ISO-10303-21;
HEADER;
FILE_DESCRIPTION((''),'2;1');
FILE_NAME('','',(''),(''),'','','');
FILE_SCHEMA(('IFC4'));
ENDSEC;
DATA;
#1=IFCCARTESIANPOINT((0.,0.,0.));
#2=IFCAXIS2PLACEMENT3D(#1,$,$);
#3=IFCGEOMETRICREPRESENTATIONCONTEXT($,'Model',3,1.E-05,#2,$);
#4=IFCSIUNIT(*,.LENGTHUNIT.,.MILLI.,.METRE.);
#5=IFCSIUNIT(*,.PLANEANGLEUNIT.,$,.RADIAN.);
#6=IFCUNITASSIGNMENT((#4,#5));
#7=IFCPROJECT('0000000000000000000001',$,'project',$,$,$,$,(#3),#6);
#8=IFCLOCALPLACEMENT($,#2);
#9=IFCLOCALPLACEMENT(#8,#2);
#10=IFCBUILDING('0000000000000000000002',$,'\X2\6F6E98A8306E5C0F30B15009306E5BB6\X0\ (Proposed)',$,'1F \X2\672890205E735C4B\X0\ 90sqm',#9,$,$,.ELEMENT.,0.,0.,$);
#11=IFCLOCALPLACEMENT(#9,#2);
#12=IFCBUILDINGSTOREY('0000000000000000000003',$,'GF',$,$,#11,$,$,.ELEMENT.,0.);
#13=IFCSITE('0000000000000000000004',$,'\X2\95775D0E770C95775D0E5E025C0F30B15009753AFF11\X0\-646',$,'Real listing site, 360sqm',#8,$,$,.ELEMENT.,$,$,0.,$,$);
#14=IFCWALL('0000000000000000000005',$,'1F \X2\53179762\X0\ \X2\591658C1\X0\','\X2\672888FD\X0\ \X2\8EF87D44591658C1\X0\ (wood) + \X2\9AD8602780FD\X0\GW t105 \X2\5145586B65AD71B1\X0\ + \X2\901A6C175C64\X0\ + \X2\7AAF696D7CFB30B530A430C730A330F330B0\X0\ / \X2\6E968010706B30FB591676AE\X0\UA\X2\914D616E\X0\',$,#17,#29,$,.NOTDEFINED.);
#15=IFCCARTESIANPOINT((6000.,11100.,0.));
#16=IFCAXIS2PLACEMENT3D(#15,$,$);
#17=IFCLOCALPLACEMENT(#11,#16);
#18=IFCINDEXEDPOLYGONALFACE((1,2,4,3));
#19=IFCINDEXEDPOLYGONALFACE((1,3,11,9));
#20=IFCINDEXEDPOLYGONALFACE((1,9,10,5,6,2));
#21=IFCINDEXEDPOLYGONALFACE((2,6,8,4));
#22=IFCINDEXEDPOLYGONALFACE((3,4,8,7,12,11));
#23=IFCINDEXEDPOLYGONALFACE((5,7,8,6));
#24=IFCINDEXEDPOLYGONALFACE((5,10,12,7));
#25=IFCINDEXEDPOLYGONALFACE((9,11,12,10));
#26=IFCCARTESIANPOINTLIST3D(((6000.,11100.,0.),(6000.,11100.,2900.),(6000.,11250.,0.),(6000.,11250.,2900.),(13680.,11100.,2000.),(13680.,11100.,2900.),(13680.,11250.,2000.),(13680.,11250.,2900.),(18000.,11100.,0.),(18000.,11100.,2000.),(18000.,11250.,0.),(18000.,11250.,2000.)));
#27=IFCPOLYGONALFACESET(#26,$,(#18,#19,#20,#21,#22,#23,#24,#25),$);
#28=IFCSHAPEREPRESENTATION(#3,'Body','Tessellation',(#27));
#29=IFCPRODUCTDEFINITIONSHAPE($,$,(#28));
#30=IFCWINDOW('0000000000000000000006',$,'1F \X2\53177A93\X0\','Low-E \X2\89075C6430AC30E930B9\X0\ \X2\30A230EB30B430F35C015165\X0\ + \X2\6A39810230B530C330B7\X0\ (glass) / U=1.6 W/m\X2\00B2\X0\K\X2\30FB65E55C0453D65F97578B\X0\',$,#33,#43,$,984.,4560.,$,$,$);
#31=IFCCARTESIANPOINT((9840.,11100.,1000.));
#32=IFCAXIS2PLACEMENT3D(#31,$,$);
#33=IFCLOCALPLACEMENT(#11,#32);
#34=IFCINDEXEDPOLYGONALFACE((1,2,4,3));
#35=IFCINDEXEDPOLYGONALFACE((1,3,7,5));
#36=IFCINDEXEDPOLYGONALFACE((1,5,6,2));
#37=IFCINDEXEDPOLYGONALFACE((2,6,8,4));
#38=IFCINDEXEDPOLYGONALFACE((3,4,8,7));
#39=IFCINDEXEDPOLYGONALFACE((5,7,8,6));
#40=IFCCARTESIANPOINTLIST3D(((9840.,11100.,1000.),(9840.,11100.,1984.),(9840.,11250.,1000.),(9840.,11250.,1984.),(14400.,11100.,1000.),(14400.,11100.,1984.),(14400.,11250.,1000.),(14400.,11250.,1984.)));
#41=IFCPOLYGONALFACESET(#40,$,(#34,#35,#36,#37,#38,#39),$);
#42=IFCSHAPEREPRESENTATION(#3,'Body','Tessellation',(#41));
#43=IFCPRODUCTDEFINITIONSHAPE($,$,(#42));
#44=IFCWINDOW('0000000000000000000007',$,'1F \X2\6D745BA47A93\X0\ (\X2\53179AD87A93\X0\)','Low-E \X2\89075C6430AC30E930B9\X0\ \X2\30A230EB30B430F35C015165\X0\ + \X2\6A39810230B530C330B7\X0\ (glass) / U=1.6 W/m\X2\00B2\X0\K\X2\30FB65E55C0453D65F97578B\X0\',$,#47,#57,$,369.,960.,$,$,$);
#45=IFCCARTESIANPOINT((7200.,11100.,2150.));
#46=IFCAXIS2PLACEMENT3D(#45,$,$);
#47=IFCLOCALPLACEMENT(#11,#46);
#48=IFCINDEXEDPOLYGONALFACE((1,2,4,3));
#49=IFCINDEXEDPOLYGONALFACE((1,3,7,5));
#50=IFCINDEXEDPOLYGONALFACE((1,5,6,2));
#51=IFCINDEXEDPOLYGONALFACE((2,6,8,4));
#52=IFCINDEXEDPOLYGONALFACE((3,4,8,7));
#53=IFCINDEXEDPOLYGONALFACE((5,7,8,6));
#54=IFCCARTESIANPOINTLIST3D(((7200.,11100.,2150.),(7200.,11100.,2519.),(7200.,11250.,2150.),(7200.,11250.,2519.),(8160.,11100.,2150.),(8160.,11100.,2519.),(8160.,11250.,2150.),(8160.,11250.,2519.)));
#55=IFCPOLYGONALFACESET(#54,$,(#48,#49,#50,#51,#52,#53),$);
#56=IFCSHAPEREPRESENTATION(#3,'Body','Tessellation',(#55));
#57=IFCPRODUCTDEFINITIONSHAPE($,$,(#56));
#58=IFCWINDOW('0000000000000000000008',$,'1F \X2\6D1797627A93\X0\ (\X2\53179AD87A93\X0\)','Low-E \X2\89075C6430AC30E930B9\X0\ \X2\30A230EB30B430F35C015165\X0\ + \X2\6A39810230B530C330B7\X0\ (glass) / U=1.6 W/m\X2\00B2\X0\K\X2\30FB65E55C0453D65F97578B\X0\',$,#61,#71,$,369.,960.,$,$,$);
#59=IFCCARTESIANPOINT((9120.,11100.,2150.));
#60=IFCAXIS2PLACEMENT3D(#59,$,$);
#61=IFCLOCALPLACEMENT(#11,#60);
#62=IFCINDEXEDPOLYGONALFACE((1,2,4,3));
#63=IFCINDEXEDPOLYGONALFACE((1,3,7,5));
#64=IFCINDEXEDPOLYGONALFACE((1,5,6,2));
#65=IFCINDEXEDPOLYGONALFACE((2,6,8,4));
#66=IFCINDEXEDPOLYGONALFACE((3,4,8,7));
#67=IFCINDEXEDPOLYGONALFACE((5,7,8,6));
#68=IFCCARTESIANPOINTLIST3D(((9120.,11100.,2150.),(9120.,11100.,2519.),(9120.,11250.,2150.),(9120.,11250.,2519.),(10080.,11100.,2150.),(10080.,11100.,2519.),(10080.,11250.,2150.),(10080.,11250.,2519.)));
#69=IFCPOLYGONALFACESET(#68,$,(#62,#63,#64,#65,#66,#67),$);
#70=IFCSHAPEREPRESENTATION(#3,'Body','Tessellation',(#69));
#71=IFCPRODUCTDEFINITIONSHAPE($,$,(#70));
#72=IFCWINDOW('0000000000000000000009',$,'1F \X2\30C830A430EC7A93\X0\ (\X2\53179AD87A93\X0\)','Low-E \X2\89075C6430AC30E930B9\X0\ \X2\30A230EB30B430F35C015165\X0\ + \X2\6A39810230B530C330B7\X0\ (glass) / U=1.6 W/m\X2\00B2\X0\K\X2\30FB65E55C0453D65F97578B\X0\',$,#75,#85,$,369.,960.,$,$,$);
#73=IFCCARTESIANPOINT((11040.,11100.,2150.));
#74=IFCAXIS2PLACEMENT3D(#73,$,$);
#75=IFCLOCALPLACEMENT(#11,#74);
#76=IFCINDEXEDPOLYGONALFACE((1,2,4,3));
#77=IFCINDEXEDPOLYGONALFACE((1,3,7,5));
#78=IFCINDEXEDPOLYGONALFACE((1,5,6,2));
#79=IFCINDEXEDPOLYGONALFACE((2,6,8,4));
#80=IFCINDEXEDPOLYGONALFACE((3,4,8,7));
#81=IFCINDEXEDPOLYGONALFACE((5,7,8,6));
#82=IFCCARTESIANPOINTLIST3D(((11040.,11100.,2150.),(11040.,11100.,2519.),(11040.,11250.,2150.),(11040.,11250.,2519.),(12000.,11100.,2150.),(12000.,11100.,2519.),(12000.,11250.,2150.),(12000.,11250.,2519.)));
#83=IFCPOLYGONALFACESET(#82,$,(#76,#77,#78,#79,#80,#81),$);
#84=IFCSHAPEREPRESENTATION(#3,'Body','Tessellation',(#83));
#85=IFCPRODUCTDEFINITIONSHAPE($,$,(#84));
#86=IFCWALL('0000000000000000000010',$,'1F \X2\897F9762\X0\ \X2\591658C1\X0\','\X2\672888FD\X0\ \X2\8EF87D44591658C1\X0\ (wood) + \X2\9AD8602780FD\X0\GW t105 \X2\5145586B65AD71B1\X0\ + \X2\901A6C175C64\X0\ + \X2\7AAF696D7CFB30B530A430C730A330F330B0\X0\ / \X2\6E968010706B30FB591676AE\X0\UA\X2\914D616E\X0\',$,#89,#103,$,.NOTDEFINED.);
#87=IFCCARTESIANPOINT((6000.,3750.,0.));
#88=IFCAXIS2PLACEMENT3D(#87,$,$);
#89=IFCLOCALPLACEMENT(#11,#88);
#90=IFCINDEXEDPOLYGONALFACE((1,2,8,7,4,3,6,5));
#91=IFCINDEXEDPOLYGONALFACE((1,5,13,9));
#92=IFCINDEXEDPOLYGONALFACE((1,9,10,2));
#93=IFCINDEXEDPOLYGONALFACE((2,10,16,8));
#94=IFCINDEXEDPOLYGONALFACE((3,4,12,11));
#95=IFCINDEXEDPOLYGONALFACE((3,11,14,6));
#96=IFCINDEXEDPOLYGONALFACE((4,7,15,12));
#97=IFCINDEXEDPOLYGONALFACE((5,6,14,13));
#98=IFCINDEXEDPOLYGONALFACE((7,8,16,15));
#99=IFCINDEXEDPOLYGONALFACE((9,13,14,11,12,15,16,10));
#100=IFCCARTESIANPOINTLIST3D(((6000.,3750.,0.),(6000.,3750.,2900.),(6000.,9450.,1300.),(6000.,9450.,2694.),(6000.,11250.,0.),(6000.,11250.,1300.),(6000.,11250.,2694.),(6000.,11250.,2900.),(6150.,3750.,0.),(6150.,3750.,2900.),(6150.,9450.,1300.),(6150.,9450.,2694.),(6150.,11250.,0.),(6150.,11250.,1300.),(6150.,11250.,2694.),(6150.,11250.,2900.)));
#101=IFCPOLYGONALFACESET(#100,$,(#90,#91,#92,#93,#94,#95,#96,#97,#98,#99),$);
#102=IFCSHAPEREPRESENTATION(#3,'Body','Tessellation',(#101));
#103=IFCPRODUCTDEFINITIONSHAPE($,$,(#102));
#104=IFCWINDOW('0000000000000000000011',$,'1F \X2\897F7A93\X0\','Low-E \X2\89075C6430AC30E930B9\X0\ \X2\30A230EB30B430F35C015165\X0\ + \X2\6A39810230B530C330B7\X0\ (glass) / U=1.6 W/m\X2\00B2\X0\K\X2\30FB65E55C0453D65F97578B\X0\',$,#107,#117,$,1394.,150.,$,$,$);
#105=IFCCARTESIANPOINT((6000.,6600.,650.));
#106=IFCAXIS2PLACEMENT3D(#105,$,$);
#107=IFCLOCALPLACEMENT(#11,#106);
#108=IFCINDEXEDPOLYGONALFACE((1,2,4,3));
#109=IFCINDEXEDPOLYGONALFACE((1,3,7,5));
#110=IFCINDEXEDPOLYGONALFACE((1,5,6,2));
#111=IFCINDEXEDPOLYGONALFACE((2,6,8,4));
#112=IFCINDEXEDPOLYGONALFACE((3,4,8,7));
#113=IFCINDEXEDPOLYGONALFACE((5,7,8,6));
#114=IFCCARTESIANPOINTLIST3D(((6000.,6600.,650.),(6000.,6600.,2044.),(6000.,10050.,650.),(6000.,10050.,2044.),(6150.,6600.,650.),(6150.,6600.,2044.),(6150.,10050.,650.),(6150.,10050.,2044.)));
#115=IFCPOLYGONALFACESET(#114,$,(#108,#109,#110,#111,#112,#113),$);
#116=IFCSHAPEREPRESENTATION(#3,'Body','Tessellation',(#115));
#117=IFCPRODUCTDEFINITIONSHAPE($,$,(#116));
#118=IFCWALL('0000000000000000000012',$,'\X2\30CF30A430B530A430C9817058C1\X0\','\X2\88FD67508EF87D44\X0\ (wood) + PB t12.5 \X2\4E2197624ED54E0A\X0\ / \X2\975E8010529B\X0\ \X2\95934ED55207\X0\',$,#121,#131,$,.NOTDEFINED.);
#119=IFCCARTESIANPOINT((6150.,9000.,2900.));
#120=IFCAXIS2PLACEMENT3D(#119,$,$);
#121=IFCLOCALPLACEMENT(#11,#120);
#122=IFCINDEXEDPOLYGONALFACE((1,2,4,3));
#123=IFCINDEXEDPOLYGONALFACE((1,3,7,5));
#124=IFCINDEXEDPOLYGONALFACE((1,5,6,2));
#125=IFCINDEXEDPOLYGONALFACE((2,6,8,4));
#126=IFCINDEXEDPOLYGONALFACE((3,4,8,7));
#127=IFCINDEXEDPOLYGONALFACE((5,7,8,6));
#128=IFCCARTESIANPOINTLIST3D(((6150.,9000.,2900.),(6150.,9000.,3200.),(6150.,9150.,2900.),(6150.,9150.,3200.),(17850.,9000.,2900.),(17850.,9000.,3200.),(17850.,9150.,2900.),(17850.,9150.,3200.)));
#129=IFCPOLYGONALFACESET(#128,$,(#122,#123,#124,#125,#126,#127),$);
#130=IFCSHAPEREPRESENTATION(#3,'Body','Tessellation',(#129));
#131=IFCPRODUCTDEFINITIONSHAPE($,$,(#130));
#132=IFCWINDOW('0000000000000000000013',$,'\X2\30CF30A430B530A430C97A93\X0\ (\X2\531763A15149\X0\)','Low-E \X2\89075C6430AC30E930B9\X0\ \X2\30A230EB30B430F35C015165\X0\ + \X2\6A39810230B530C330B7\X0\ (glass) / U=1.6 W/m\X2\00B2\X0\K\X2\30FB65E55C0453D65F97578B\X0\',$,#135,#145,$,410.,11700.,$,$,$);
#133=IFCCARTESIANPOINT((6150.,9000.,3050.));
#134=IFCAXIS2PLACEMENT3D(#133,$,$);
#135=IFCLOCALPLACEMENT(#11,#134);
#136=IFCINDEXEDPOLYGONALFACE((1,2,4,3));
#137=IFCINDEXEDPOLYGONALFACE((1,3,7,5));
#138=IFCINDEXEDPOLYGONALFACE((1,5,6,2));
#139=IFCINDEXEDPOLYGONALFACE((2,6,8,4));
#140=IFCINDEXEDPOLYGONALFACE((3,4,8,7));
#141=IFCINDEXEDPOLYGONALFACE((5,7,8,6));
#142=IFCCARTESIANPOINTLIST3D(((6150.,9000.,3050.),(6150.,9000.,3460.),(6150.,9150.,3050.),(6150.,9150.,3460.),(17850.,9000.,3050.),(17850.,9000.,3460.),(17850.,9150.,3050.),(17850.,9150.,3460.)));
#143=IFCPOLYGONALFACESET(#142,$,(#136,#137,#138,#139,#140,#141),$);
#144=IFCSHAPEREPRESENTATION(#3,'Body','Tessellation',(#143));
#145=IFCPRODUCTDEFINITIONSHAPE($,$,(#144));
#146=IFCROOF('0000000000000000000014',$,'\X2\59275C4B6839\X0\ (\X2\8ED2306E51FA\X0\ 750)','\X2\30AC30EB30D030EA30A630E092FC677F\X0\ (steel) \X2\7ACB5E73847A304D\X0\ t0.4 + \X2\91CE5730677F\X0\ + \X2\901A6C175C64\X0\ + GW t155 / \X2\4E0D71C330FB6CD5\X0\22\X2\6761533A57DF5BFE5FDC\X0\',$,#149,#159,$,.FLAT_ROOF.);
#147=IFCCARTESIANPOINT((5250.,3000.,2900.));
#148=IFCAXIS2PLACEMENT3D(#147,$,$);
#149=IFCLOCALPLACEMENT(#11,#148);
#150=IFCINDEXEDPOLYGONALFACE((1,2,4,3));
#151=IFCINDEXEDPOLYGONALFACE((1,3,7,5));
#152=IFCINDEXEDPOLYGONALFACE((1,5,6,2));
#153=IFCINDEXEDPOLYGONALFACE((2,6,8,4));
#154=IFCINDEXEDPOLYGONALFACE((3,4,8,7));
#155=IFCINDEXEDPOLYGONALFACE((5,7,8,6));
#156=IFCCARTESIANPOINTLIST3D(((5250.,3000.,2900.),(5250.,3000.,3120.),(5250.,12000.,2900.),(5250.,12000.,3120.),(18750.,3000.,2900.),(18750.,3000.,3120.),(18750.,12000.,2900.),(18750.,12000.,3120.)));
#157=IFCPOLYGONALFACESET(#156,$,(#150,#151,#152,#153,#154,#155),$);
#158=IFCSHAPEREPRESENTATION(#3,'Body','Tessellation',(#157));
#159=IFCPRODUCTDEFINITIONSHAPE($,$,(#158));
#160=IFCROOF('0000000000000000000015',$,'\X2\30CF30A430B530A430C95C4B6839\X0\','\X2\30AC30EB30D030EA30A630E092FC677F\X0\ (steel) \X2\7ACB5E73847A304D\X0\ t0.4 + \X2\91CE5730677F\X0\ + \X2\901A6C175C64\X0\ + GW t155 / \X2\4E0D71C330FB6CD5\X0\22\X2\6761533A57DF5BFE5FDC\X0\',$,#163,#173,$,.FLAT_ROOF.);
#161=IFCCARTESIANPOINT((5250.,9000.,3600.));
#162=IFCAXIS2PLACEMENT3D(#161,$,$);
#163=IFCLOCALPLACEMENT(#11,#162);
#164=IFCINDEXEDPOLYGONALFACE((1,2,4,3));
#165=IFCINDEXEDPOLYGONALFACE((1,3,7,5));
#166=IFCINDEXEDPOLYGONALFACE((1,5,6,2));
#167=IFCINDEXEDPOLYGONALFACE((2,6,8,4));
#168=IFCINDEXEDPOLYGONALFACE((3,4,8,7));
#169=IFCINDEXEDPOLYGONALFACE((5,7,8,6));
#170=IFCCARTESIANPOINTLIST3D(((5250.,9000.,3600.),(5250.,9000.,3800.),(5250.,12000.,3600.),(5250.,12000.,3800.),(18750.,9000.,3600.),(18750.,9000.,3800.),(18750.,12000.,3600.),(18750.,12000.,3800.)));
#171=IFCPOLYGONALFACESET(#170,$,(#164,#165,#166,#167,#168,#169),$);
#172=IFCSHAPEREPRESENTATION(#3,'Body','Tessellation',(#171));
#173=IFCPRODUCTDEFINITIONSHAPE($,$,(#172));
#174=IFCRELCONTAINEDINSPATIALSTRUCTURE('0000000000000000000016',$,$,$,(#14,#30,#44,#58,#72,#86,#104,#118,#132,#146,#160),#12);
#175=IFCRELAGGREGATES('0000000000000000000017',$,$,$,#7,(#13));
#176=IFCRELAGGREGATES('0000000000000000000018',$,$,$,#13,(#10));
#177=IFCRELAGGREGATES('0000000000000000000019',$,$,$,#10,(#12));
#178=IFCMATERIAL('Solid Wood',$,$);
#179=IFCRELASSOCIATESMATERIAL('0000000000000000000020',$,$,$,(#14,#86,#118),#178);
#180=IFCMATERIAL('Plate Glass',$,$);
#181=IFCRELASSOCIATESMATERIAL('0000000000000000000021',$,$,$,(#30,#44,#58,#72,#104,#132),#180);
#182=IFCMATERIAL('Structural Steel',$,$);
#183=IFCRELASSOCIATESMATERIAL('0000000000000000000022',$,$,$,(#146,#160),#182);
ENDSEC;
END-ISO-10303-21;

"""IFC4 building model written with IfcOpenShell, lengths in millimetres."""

from ifc_helpers import new_model, si_unit, frame, frame_2d, origin, place, context, project, spatial, rectangle, extrude, material, element, fill, save


model = new_model("IFC4")

# Units and contexts
model_context = context("Model", 3, precision=1e-05, world=origin())
ifc_project = project(units=[si_unit("LENGTHUNIT", "METRE", prefix="MILLI"), si_unit("PLANEANGLEUNIT", "RADIAN")], contexts=[model_context])

# Site, building, storey
site_placement = place(None, origin())
site = spatial("IfcSite", under=ifc_project, at=site_placement, Name="長崎県長崎市小ケ倉町１-646", ObjectType="Real listing site, 360sqm", CompositionType="ELEMENT", RefElevation=0.0)
building_placement = place(site_placement, origin())
building = spatial("IfcBuilding", under=site, at=building_placement, Name="潮風の小ケ倉の家 (Proposed)", ObjectType="1F 木造平屋 90sqm", CompositionType="ELEMENT", ElevationOfRefHeight=0.0, ElevationOfTerrain=0.0)
storey_placement = place(building_placement, origin())
storey = spatial("IfcBuildingStorey", under=building, at=storey_placement, Name="GF", CompositionType="ELEMENT", Elevation=0.0)

# Shared definitions
ifc_material_1 = material(Name="Solid Wood")

# Shared definitions
ifc_material_2 = material(Name="Plate Glass")

# Wall, openings, windows
wall_1_placement = place(storey_placement, frame((6000.0, 11100.0, 0.0)))
wall_1 = element("IfcWall", 1, at=wall_1_placement, inside=storey, material=ifc_material_1, Name="1F 北面 外壁", Description="木製 軸組外壁 (wood) + 高性能GW t105 充填断熱 + 通気層 + 窯業系サイディング / 準耐火・外皮UA配慮", PredefinedType="NOTDEFINED", context=model_context, shape_type="SweptSolid", body=[
    extrude(rectangle(XDim=12000.0, YDim=150.0, at=frame_2d((6000.0, 75.0))), frame((6000.0, 11100.0, 0.0)), (0.0, 0.0, 1.0), 2900.0),
])
opening_1_placement = place(storey_placement, frame((9840.0, 11100.0, 1000.0)))
opening_1 = element("IfcOpeningElement", 2, at=opening_1_placement, cuts=wall_1, PredefinedType="NOTDEFINED", context=model_context, shape_type="SweptSolid", body=[
    extrude(rectangle(XDim=4560.0, YDim=150.0, at=frame_2d((2280.0, 75.0))), frame((9840.0, 11100.0, 1000.0)), (0.0, 0.0, 1.0), 984.0),
])
opening_2_placement = place(storey_placement, frame((7200.0, 11100.0, 2150.0)))
opening_2 = element("IfcOpeningElement", 3, at=opening_2_placement, cuts=wall_1, PredefinedType="NOTDEFINED", context=model_context, shape_type="SweptSolid", body=[
    extrude(rectangle(XDim=960.0, YDim=150.0, at=frame_2d((480.0, 75.0))), frame((7200.0, 11100.0, 2150.0)), (0.0, 0.0, 1.0), 369.0),
])
opening_3_placement = place(storey_placement, frame((9120.0, 11100.0, 2150.0)))
opening_3 = element("IfcOpeningElement", 4, at=opening_3_placement, cuts=wall_1, PredefinedType="NOTDEFINED", context=model_context, shape_type="SweptSolid", body=[
    extrude(rectangle(XDim=960.0, YDim=150.0, at=frame_2d((480.0, 75.0))), frame((9120.0, 11100.0, 2150.0)), (0.0, 0.0, 1.0), 369.0),
])
opening_4_placement = place(storey_placement, frame((11040.0, 11100.0, 2150.0)))
opening_4 = element("IfcOpeningElement", 5, at=opening_4_placement, cuts=wall_1, PredefinedType="NOTDEFINED", context=model_context, shape_type="SweptSolid", body=[
    extrude(rectangle(XDim=960.0, YDim=150.0, at=frame_2d((480.0, 75.0))), frame((11040.0, 11100.0, 2150.0)), (0.0, 0.0, 1.0), 369.0),
])
window_1_placement = place(storey_placement, frame((9840.0, 11100.0, 1000.0)))
window_1 = element("IfcWindow", 6, at=window_1_placement, inside=storey, material=ifc_material_2, Name="1F 北窓", Description="Low-E 複層ガラス アルゴン封入 + 樹脂サッシ (glass) / U=1.6 W/m²K・日射取得型", OverallHeight=984.0, OverallWidth=4560.0, context=model_context, shape_type="SweptSolid", body=[
    extrude(rectangle(XDim=4560.0, YDim=150.0, at=frame_2d((2280.0, 75.0))), frame((9840.0, 11100.0, 1000.0)), (0.0, 0.0, 1.0), 984.0),
])
fill(opening_1, window_1)
window_2_placement = place(storey_placement, frame((7200.0, 11100.0, 2150.0)))
window_2 = element("IfcWindow", 7, at=window_2_placement, inside=storey, material=ifc_material_2, Name="1F 浴室窓 (北高窓)", Description="Low-E 複層ガラス アルゴン封入 + 樹脂サッシ (glass) / U=1.6 W/m²K・日射取得型", OverallHeight=369.0, OverallWidth=960.0, context=model_context, shape_type="SweptSolid", body=[
    extrude(rectangle(XDim=960.0, YDim=150.0, at=frame_2d((480.0, 75.0))), frame((7200.0, 11100.0, 2150.0)), (0.0, 0.0, 1.0), 369.0),
])
fill(opening_2, window_2)
window_3_placement = place(storey_placement, frame((9120.0, 11100.0, 2150.0)))
window_3 = element("IfcWindow", 8, at=window_3_placement, inside=storey, material=ifc_material_2, Name="1F 洗面窓 (北高窓)", Description="Low-E 複層ガラス アルゴン封入 + 樹脂サッシ (glass) / U=1.6 W/m²K・日射取得型", OverallHeight=369.0, OverallWidth=960.0, context=model_context, shape_type="SweptSolid", body=[
    extrude(rectangle(XDim=960.0, YDim=150.0, at=frame_2d((480.0, 75.0))), frame((9120.0, 11100.0, 2150.0)), (0.0, 0.0, 1.0), 369.0),
])
fill(opening_3, window_3)
window_4_placement = place(storey_placement, frame((11040.0, 11100.0, 2150.0)))
window_4 = element("IfcWindow", 9, at=window_4_placement, inside=storey, material=ifc_material_2, Name="1F トイレ窓 (北高窓)", Description="Low-E 複層ガラス アルゴン封入 + 樹脂サッシ (glass) / U=1.6 W/m²K・日射取得型", OverallHeight=369.0, OverallWidth=960.0, context=model_context, shape_type="SweptSolid", body=[
    extrude(rectangle(XDim=960.0, YDim=150.0, at=frame_2d((480.0, 75.0))), frame((11040.0, 11100.0, 2150.0)), (0.0, 0.0, 1.0), 369.0),
])
fill(opening_4, window_4)

# Wall, opening, window
wall_2_placement = place(storey_placement, frame((6000.0, 3750.0, 0.0)))
wall_2 = element("IfcWall", 10, at=wall_2_placement, inside=storey, material=ifc_material_1, Name="1F 西面 外壁", Description="木製 軸組外壁 (wood) + 高性能GW t105 充填断熱 + 通気層 + 窯業系サイディング / 準耐火・外皮UA配慮", PredefinedType="NOTDEFINED", context=model_context, shape_type="SweptSolid", body=[
    extrude(rectangle(XDim=150.0, YDim=7500.0, at=frame_2d((75.0, 3750.0))), frame((6000.0, 3750.0, 0.0)), (0.0, 0.0, 1.0), 2900.0),
])
opening_5_placement = place(storey_placement, frame((6000.0, 6600.0, 650.0)))
opening_5 = element("IfcOpeningElement", 11, at=opening_5_placement, cuts=wall_2, PredefinedType="NOTDEFINED", context=model_context, shape_type="SweptSolid", body=[
    extrude(rectangle(XDim=150.0, YDim=3450.0, at=frame_2d((75.0, 1725.0))), frame((6000.0, 6600.0, 650.0)), (0.0, 0.0, 1.0), 1394.0),
])
window_5_placement = place(storey_placement, frame((6000.0, 6600.0, 650.0)))
window_5 = element("IfcWindow", 12, at=window_5_placement, inside=storey, material=ifc_material_2, Name="1F 西窓", Description="Low-E 複層ガラス アルゴン封入 + 樹脂サッシ (glass) / U=1.6 W/m²K・日射取得型", OverallHeight=1394.0, OverallWidth=150.0, context=model_context, shape_type="SweptSolid", body=[
    extrude(rectangle(XDim=150.0, YDim=3450.0, at=frame_2d((75.0, 1725.0))), frame((6000.0, 6600.0, 650.0)), (0.0, 0.0, 1.0), 1394.0),
])
fill(opening_5, window_5)

# Wall, opening, window
wall_3_placement = place(storey_placement, frame((6150.0, 9000.0, 2900.0)))
wall_3 = element("IfcWall", 13, at=wall_3_placement, inside=storey, material=ifc_material_1, Name="ハイサイド腰壁", Description="製材軸組 (wood) + PB t12.5 両面仕上 / 非耐力 間仕切", PredefinedType="NOTDEFINED", context=model_context, shape_type="SweptSolid", body=[
    extrude(rectangle(XDim=11700.0, YDim=150.0, at=frame_2d((5850.0, 75.0))), frame((6150.0, 9000.0, 2900.0)), (0.0, 0.0, 1.0), 700.0),
])
opening_6_placement = place(storey_placement, frame((6150.0, 9000.0, 3050.0)))
opening_6 = element("IfcOpeningElement", 14, at=opening_6_placement, cuts=wall_3, PredefinedType="NOTDEFINED", context=model_context, shape_type="SweptSolid", body=[
    extrude(rectangle(XDim=11700.0, YDim=150.0, at=frame_2d((5850.0, 75.0))), frame((6150.0, 9000.0, 3050.0)), (0.0, 0.0, 1.0), 410.0),
])
window_6_placement = place(storey_placement, frame((6150.0, 9000.0, 3050.0)))
window_6 = element("IfcWindow", 15, at=window_6_placement, inside=storey, material=ifc_material_2, Name="ハイサイド窓 (北採光)", Description="Low-E 複層ガラス アルゴン封入 + 樹脂サッシ (glass) / U=1.6 W/m²K・日射取得型", OverallHeight=410.0, OverallWidth=11700.0, context=model_context, shape_type="SweptSolid", body=[
    extrude(rectangle(XDim=11700.0, YDim=150.0, at=frame_2d((5850.0, 75.0))), frame((6150.0, 9000.0, 3050.0)), (0.0, 0.0, 1.0), 410.0),
])
fill(opening_6, window_6)

# Roofs
ifc_material_3 = material(Name="Structural Steel")
roof_1_placement = place(storey_placement, frame((5250.0, 3000.0, 2900.0)))
element("IfcRoof", 16, at=roof_1_placement, inside=storey, material=ifc_material_3, Name="大屋根 (軒の出 750)", Description="ガルバリウム鋼板 (steel) 立平葺き t0.4 + 野地板 + 通気層 + GW t155 / 不燃・法22条区域対応", PredefinedType="FLAT_ROOF", context=model_context, shape_type="SweptSolid", body=[
    extrude(rectangle(XDim=13500.0, YDim=9000.0, at=frame_2d((6750.0, 4500.0))), frame((5250.0, 3000.0, 2900.0)), (0.0, 0.0, 1.0), 220.0),
])
roof_2_placement = place(storey_placement, frame((5250.0, 9000.0, 3600.0)))
element("IfcRoof", 17, at=roof_2_placement, inside=storey, material=ifc_material_3, Name="ハイサイド屋根", Description="ガルバリウム鋼板 (steel) 立平葺き t0.4 + 野地板 + 通気層 + GW t155 / 不燃・法22条区域対応", PredefinedType="FLAT_ROOF", context=model_context, shape_type="SweptSolid", body=[
    extrude(rectangle(XDim=13500.0, YDim=3000.0, at=frame_2d((6750.0, 1500.0))), frame((5250.0, 9000.0, 3600.0)), (0.0, 0.0, 1.0), 200.0),
])

save(model, "model.ifc")
